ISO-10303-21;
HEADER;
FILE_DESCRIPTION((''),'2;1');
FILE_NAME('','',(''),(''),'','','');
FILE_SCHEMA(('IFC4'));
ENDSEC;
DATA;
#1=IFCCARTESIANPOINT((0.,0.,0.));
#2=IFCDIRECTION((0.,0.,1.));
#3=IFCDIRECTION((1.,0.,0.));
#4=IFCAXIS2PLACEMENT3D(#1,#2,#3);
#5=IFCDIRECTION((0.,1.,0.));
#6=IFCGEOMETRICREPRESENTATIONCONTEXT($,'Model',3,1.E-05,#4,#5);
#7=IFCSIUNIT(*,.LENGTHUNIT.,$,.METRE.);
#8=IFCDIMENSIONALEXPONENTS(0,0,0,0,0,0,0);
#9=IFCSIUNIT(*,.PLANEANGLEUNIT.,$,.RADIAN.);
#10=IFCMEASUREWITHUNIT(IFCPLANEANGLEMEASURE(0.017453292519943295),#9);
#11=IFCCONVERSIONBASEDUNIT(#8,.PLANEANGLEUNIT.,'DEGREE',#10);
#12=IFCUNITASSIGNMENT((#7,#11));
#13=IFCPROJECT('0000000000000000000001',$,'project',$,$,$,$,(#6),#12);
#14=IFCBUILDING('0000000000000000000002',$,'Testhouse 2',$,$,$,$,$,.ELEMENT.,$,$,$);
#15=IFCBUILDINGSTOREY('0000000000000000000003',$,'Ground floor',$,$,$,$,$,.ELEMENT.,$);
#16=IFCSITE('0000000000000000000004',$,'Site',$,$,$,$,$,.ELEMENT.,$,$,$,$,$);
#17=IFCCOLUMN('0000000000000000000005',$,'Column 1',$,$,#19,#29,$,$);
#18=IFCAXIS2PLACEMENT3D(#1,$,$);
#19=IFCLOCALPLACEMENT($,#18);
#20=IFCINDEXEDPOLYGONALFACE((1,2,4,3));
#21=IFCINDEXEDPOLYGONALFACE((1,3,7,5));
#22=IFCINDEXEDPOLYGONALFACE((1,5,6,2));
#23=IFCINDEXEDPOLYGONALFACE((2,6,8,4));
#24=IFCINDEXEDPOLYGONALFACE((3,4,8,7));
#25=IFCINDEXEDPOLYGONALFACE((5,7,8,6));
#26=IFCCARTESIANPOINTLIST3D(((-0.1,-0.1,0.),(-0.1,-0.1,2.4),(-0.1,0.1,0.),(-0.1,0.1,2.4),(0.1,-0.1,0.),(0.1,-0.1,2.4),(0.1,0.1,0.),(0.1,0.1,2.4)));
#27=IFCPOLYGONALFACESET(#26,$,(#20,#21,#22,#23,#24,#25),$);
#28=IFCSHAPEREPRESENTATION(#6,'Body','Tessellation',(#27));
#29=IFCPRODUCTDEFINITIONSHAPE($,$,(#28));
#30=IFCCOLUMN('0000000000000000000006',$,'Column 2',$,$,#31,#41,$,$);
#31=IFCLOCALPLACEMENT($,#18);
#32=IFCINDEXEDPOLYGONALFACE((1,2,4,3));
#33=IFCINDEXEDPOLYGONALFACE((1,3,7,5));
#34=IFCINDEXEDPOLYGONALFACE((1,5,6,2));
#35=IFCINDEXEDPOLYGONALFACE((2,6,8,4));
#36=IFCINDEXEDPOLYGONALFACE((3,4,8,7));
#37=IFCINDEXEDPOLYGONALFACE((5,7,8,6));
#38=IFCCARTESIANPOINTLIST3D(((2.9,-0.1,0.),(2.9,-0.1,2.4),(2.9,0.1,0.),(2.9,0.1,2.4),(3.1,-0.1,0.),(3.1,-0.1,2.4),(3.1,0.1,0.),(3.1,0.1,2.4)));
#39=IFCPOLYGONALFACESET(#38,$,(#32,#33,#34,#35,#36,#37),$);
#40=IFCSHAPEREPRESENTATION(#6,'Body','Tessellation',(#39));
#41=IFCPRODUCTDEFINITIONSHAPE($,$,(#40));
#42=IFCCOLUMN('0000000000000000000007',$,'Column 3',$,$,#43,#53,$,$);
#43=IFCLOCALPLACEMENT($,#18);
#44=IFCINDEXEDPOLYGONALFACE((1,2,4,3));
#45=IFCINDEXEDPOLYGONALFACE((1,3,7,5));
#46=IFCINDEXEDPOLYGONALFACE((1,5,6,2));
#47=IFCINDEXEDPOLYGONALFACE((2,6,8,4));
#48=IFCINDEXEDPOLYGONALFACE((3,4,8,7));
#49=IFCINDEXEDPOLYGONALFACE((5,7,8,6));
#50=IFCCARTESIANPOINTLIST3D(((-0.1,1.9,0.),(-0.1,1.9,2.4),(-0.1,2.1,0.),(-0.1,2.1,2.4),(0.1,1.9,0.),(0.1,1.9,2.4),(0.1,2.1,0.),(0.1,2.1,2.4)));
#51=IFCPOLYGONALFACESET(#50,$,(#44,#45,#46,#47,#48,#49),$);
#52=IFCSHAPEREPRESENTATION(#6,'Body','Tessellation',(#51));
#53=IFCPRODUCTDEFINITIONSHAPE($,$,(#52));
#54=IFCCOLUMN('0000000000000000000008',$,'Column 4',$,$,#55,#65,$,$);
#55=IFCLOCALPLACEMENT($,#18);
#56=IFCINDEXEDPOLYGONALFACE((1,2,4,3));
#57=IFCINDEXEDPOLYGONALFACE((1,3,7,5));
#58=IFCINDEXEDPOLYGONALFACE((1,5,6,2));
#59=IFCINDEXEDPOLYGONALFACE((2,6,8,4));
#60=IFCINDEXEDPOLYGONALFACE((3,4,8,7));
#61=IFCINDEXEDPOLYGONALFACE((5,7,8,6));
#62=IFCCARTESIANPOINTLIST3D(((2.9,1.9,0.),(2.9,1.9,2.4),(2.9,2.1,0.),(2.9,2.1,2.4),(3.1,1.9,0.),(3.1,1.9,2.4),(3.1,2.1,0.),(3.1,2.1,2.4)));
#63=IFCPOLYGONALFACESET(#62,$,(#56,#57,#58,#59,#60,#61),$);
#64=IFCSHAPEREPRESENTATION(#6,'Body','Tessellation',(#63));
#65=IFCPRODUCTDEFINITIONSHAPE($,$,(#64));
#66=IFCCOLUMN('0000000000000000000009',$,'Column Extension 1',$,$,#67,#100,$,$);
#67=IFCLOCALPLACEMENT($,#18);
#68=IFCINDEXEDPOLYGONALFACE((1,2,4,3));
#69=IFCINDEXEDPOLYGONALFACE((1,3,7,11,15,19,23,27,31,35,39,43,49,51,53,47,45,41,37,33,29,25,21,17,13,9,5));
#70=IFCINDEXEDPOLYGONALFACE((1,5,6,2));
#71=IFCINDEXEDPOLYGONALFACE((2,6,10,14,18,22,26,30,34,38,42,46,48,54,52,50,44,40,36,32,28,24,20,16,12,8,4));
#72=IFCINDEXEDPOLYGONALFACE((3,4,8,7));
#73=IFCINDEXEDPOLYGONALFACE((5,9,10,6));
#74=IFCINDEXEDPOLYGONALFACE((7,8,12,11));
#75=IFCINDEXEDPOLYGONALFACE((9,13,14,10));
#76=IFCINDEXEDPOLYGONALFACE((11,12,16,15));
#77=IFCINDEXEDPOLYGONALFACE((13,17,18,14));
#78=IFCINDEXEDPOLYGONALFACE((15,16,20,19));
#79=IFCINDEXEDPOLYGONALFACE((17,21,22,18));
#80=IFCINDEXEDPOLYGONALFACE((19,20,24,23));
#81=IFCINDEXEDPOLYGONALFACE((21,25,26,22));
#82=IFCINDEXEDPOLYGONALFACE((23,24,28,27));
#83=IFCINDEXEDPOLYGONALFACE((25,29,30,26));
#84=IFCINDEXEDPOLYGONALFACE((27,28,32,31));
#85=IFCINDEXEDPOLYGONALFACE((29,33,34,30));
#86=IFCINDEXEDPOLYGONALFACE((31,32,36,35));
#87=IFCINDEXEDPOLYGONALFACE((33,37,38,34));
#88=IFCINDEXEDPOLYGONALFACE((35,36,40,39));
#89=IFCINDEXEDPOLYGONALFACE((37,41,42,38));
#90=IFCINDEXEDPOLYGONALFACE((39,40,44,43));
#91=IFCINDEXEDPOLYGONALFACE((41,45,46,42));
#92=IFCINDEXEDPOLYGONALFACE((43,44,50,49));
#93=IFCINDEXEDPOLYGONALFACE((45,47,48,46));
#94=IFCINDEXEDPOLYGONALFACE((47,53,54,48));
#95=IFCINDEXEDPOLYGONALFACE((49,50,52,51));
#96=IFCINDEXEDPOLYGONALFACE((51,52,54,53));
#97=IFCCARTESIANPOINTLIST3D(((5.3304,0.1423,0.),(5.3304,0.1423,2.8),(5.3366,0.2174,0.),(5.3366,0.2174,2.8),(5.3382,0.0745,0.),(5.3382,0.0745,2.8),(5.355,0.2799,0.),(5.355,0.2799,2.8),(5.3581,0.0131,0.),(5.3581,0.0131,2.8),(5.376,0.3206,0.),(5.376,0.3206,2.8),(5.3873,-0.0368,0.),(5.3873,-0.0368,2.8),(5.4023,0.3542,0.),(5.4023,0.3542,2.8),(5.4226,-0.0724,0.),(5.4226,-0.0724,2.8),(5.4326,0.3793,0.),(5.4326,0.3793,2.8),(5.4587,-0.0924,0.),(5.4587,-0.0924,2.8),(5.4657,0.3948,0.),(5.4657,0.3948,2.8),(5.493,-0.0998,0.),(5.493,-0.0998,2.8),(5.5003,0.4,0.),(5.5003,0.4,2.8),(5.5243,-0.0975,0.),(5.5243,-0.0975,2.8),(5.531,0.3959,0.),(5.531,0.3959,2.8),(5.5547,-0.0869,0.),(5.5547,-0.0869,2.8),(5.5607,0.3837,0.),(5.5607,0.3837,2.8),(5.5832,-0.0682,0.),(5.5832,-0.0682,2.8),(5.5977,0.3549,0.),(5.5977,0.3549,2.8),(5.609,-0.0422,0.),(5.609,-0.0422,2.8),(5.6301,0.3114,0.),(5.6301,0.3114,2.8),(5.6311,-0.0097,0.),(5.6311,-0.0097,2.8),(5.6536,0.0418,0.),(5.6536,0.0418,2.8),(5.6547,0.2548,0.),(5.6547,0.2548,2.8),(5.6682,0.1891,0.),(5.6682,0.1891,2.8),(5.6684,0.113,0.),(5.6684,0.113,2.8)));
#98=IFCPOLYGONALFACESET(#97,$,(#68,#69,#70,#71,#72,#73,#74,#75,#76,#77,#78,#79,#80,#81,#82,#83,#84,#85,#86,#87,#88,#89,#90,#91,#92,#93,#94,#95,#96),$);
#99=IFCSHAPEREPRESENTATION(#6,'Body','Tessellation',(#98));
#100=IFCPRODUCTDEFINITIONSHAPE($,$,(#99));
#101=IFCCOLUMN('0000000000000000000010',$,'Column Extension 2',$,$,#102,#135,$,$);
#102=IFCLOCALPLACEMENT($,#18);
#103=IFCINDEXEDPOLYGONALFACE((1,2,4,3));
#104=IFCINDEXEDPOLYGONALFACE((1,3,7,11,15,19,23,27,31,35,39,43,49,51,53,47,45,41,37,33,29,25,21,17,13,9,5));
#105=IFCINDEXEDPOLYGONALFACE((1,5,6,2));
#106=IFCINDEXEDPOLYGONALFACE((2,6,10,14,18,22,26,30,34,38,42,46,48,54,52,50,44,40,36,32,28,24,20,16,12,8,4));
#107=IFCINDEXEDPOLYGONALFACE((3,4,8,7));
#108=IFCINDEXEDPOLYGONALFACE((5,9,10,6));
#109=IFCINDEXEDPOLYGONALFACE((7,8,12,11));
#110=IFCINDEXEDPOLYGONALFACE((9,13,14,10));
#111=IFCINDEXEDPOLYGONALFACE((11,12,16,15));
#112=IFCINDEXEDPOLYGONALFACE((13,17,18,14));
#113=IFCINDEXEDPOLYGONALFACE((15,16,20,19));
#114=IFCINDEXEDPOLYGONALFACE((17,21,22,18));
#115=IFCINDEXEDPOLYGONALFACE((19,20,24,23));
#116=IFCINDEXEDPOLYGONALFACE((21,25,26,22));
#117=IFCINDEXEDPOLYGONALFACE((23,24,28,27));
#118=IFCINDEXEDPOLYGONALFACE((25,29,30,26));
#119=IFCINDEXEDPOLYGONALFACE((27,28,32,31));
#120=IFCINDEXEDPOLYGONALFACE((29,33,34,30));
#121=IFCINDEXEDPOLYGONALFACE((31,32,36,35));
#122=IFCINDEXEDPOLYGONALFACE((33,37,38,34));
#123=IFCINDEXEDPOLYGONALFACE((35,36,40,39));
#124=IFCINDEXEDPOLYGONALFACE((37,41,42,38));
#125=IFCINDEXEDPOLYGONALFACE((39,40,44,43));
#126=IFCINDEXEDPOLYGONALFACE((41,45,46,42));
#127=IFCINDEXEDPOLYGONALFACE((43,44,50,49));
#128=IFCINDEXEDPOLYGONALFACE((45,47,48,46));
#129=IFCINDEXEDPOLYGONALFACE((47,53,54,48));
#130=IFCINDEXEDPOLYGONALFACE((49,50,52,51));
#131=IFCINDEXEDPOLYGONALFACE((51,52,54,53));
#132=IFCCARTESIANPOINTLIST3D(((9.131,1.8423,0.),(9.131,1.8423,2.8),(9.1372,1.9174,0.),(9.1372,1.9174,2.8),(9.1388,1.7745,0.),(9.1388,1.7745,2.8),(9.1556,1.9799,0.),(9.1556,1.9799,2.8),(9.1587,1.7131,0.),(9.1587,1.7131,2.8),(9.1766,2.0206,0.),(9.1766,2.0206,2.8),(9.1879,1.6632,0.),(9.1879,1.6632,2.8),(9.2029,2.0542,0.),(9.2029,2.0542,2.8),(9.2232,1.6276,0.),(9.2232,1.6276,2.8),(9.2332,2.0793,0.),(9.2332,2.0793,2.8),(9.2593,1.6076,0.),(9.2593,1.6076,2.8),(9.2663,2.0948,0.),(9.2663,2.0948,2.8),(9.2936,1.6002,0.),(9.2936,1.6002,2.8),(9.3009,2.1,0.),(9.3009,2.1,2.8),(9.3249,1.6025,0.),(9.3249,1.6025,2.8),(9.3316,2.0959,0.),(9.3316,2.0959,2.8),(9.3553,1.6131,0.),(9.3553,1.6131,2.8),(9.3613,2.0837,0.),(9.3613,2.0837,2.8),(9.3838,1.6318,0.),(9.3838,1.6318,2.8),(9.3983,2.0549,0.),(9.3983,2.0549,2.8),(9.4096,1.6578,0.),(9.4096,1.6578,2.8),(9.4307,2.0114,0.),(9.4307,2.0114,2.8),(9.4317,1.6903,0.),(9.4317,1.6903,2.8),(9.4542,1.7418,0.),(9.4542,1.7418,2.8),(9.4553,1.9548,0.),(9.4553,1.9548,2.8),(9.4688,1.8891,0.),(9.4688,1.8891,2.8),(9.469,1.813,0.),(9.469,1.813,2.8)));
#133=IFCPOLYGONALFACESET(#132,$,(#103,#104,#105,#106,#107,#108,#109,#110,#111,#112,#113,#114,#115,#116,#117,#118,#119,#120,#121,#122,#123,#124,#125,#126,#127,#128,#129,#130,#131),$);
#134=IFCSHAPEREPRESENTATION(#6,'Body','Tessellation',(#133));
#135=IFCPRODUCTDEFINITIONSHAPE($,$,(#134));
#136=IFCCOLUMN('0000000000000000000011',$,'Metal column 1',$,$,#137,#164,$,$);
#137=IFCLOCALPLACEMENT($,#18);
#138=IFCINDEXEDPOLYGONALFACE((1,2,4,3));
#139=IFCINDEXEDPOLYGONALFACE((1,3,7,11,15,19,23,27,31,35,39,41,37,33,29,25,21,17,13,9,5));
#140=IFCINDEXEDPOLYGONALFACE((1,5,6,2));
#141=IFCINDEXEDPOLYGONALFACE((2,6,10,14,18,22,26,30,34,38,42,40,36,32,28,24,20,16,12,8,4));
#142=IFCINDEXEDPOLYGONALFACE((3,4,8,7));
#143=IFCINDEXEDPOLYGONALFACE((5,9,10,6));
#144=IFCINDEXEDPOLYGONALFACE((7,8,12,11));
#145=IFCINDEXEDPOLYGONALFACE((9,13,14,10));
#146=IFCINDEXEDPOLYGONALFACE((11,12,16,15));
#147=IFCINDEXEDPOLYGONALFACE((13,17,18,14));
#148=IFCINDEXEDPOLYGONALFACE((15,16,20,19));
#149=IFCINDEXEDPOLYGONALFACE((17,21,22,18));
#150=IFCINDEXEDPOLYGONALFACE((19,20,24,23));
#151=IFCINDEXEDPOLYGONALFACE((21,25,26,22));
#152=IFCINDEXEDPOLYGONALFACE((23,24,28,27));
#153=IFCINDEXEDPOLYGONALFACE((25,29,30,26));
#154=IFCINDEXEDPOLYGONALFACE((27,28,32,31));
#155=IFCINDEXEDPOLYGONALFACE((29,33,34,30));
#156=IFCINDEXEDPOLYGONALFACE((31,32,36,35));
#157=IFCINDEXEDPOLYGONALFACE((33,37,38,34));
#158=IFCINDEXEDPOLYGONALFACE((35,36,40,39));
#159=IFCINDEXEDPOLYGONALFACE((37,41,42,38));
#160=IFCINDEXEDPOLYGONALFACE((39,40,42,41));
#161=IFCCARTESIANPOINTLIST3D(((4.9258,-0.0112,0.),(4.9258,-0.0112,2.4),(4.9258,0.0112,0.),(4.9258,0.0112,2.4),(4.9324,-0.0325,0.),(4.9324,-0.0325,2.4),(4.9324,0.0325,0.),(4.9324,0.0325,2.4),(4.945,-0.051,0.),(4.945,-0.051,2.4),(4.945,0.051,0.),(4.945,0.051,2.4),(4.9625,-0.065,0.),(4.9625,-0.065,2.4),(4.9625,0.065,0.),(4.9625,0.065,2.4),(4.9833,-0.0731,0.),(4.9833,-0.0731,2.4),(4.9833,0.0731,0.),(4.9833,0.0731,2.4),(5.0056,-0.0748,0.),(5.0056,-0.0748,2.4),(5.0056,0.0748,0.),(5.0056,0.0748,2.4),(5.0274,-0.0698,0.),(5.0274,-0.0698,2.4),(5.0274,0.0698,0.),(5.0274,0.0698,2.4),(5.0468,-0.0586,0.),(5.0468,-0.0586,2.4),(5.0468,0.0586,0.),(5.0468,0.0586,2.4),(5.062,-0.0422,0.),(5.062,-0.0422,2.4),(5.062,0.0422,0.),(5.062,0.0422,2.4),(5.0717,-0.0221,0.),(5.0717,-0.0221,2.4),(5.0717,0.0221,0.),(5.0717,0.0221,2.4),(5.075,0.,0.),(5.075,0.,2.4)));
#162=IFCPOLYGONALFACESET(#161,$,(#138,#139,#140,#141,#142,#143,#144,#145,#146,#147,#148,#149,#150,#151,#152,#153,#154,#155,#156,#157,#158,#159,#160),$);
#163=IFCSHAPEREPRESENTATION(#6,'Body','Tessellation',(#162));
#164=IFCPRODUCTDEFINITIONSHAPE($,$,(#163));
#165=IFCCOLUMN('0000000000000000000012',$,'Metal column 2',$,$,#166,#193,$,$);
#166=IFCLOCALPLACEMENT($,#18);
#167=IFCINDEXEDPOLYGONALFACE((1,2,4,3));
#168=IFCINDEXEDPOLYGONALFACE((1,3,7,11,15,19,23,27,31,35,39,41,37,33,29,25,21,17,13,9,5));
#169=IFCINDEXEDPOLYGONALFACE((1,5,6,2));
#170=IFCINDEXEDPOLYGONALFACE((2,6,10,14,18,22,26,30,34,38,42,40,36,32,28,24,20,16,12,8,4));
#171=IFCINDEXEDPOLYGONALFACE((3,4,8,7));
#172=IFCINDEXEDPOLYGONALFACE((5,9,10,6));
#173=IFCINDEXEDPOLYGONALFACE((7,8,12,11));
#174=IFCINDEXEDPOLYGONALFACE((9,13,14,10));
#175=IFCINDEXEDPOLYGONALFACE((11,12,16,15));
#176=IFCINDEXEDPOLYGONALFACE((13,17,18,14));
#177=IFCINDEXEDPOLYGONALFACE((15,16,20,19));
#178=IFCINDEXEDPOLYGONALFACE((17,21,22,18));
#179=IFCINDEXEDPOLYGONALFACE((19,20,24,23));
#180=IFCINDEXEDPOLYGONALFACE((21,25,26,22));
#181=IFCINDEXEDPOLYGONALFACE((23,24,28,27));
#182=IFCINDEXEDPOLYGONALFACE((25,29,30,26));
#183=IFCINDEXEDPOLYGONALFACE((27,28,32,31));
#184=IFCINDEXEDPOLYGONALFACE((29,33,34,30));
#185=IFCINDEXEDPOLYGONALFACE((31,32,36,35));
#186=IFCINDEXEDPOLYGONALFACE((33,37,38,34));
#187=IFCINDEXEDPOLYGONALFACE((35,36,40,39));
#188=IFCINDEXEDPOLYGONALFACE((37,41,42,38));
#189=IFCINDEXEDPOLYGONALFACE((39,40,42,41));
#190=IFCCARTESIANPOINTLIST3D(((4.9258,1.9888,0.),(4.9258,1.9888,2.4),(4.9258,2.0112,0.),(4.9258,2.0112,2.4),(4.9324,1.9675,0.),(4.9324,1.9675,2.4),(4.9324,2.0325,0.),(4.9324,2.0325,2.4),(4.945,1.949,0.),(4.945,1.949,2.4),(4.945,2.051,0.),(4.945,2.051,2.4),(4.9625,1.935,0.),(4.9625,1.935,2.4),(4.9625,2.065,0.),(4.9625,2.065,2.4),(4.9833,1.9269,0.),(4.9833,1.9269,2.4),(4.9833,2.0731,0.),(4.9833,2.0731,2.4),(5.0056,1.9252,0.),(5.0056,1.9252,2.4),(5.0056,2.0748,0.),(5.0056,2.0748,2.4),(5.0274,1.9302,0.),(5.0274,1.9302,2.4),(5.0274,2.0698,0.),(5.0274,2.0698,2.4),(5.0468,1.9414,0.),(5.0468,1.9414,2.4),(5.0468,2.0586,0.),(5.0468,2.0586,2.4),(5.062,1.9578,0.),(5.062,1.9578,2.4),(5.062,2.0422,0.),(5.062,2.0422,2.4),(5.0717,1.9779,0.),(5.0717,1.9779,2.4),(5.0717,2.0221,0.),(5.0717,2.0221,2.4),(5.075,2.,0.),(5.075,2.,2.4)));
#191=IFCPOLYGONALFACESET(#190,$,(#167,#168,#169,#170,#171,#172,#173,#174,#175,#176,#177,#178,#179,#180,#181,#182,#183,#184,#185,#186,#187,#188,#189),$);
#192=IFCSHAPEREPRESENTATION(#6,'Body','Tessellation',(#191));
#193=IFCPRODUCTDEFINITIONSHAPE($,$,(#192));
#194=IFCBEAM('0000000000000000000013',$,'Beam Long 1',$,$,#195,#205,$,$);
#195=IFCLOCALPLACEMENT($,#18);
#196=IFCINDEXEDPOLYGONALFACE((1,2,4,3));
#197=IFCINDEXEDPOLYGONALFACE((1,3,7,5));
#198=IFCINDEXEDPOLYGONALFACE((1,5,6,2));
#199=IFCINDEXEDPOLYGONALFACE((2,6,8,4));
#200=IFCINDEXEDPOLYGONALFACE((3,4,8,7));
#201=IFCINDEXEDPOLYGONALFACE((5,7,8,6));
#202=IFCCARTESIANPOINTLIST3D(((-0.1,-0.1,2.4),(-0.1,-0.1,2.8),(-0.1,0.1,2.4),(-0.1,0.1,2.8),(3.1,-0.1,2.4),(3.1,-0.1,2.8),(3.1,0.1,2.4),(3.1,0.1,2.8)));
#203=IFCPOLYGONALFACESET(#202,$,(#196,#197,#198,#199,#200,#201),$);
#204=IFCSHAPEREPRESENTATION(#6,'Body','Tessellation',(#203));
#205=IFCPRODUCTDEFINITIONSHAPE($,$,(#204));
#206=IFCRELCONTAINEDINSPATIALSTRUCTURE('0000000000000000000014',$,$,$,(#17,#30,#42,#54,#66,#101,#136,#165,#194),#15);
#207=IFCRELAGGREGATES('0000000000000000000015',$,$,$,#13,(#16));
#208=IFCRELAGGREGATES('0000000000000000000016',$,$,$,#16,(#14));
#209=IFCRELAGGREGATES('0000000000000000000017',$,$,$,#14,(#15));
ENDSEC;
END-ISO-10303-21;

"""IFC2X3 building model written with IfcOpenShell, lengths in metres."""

from ifc_helpers import new_model, entity, si_unit, converted_unit, direction, frame, origin_with_axes, origin_2d_with_axis, place, context, project, spatial, polyline, circle, ellipse, outline, extrude, element, save


model = new_model("IFC2X3")

# Units and contexts
model_context = context("Model", 3, precision=1e-05, world=origin_with_axes(), true_north=direction((0.0, 1.0, 0.0)))
ifc_project = project(units=[si_unit("LENGTHUNIT", "METRE"), converted_unit("PLANEANGLEUNIT", "DEGREE", entity("IfcPlaneAngleMeasure", 0.017453292519943295), si_unit("PLANEANGLEUNIT", "RADIAN"), dimensions=[0, 0, 0, 0, 0, 0, 0])], contexts=[model_context])

# Site, building, storey
site = spatial("IfcSite", under=ifc_project, Name="Site", CompositionType="ELEMENT")
building = spatial("IfcBuilding", under=site, Name="Testhouse 2", CompositionType="ELEMENT")
storey = spatial("IfcBuildingStorey", under=building, Name="Ground floor", CompositionType="ELEMENT")

# Columns
column_1_placement = place(None, origin_with_axes())
element("IfcColumn", 1, at=column_1_placement, inside=storey, Name="Column 1", context=model_context, shape_type="SweptSolid", body=[
    extrude(outline(polyline([(-0.1, -0.1), (0.1, -0.1), (0.1, 0.1), (-0.1, 0.1), (-0.1, -0.1)])), origin_with_axes(), (0.0, 0.0, 1.0), 2.4),
])
column_2_placement = place(None, origin_with_axes())
element("IfcColumn", 2, at=column_2_placement, inside=storey, Name="Column 2", context=model_context, shape_type="SweptSolid", body=[
    extrude(outline(polyline([(-0.1, -0.1), (0.1, -0.1), (0.1, 0.1), (-0.1, 0.1), (-0.1, -0.1)])), frame((3.0, 0.0, 0.0), z_axis=(0.0, 0.0, 1.0), x_axis=(1.0, 0.0, 0.0)), (0.0, 0.0, 1.0), 2.4),
])
column_3_placement = place(None, origin_with_axes())
element("IfcColumn", 3, at=column_3_placement, inside=storey, Name="Column 3", context=model_context, shape_type="SweptSolid", body=[
    extrude(outline(polyline([(-0.1, -0.1), (0.1, -0.1), (0.1, 0.1), (-0.1, 0.1), (-0.1, -0.1)])), frame((0.0, 2.0, 0.0), z_axis=(0.0, 0.0, 1.0), x_axis=(1.0, 0.0, 0.0)), (0.0, 0.0, 1.0), 2.4),
])
column_4_placement = place(None, origin_with_axes())
element("IfcColumn", 4, at=column_4_placement, inside=storey, Name="Column 4", context=model_context, shape_type="SweptSolid", body=[
    extrude(outline(polyline([(-0.1, -0.1), (0.1, -0.1), (0.1, 0.1), (-0.1, 0.1), (-0.1, -0.1)])), frame((3.0, 2.0, 0.0), z_axis=(0.0, 0.0, 1.0), x_axis=(1.0, 0.0, 0.0)), (0.0, 0.0, 1.0), 2.4),
])
column_5_placement = place(None, origin_with_axes())
element("IfcColumn", 5, at=column_5_placement, inside=storey, Name="Column Extension 1", context=model_context, shape_type="SweptSolid", body=[
    extrude(ellipse(SemiAxis1=0.25, SemiAxis2=0.17, at=origin_2d_with_axis()), frame((5.5003, 0.15, 0.0), z_axis=(0.0, 0.0, 1.0), x_axis=(0.0, 1.0, 0.0)), (0.0, 0.0, 1.0), 2.8),
])
column_6_placement = place(None, origin_with_axes())
element("IfcColumn", 6, at=column_6_placement, inside=storey, Name="Column Extension 2", context=model_context, shape_type="SweptSolid", body=[
    extrude(ellipse(SemiAxis1=0.25, SemiAxis2=0.17, at=origin_2d_with_axis()), frame((9.3009, 1.85, 0.0), z_axis=(0.0, 0.0, 1.0), x_axis=(0.0, 1.0, 0.0)), (0.0, 0.0, 1.0), 2.8),
])
column_7_placement = place(None, origin_with_axes())
element("IfcColumn", 7, at=column_7_placement, inside=storey, Name="Metal column 1", context=model_context, shape_type="SweptSolid", body=[
    extrude(circle(Radius=0.075, at=origin_2d_with_axis()), frame((5.0, 0.0, 0.0), z_axis=(0.0, 0.0, 1.0), x_axis=(1.0, 0.0, 0.0)), (0.0, 0.0, 1.0), 2.4),
])
column_8_placement = place(None, origin_with_axes())
element("IfcColumn", 8, at=column_8_placement, inside=storey, Name="Metal column 2", context=model_context, shape_type="SweptSolid", body=[
    extrude(circle(Radius=0.075, at=origin_2d_with_axis()), frame((5.0, 2.0, 0.0), z_axis=(0.0, 0.0, 1.0), x_axis=(1.0, 0.0, 0.0)), (0.0, 0.0, 1.0), 2.4),
])

# Beam
beam_1_placement = place(None, origin_with_axes())
element("IfcBeam", 9, at=beam_1_placement, inside=storey, Name="Beam Long 1", context=model_context, shape_type="SweptSolid", body=[
    extrude(outline(polyline([(-0.2, -0.1), (0.2, -0.1), (0.2, 0.1), (-0.2, 0.1), (-0.2, -0.1)])), frame((-0.1, 0.0, 2.6), z_axis=(1.0, 0.0, 0.0), x_axis=(0.0, 0.0, -1.0)), (0.0, 0.0, 1.0), 3.2),
])

save(model, "model.ifc")
